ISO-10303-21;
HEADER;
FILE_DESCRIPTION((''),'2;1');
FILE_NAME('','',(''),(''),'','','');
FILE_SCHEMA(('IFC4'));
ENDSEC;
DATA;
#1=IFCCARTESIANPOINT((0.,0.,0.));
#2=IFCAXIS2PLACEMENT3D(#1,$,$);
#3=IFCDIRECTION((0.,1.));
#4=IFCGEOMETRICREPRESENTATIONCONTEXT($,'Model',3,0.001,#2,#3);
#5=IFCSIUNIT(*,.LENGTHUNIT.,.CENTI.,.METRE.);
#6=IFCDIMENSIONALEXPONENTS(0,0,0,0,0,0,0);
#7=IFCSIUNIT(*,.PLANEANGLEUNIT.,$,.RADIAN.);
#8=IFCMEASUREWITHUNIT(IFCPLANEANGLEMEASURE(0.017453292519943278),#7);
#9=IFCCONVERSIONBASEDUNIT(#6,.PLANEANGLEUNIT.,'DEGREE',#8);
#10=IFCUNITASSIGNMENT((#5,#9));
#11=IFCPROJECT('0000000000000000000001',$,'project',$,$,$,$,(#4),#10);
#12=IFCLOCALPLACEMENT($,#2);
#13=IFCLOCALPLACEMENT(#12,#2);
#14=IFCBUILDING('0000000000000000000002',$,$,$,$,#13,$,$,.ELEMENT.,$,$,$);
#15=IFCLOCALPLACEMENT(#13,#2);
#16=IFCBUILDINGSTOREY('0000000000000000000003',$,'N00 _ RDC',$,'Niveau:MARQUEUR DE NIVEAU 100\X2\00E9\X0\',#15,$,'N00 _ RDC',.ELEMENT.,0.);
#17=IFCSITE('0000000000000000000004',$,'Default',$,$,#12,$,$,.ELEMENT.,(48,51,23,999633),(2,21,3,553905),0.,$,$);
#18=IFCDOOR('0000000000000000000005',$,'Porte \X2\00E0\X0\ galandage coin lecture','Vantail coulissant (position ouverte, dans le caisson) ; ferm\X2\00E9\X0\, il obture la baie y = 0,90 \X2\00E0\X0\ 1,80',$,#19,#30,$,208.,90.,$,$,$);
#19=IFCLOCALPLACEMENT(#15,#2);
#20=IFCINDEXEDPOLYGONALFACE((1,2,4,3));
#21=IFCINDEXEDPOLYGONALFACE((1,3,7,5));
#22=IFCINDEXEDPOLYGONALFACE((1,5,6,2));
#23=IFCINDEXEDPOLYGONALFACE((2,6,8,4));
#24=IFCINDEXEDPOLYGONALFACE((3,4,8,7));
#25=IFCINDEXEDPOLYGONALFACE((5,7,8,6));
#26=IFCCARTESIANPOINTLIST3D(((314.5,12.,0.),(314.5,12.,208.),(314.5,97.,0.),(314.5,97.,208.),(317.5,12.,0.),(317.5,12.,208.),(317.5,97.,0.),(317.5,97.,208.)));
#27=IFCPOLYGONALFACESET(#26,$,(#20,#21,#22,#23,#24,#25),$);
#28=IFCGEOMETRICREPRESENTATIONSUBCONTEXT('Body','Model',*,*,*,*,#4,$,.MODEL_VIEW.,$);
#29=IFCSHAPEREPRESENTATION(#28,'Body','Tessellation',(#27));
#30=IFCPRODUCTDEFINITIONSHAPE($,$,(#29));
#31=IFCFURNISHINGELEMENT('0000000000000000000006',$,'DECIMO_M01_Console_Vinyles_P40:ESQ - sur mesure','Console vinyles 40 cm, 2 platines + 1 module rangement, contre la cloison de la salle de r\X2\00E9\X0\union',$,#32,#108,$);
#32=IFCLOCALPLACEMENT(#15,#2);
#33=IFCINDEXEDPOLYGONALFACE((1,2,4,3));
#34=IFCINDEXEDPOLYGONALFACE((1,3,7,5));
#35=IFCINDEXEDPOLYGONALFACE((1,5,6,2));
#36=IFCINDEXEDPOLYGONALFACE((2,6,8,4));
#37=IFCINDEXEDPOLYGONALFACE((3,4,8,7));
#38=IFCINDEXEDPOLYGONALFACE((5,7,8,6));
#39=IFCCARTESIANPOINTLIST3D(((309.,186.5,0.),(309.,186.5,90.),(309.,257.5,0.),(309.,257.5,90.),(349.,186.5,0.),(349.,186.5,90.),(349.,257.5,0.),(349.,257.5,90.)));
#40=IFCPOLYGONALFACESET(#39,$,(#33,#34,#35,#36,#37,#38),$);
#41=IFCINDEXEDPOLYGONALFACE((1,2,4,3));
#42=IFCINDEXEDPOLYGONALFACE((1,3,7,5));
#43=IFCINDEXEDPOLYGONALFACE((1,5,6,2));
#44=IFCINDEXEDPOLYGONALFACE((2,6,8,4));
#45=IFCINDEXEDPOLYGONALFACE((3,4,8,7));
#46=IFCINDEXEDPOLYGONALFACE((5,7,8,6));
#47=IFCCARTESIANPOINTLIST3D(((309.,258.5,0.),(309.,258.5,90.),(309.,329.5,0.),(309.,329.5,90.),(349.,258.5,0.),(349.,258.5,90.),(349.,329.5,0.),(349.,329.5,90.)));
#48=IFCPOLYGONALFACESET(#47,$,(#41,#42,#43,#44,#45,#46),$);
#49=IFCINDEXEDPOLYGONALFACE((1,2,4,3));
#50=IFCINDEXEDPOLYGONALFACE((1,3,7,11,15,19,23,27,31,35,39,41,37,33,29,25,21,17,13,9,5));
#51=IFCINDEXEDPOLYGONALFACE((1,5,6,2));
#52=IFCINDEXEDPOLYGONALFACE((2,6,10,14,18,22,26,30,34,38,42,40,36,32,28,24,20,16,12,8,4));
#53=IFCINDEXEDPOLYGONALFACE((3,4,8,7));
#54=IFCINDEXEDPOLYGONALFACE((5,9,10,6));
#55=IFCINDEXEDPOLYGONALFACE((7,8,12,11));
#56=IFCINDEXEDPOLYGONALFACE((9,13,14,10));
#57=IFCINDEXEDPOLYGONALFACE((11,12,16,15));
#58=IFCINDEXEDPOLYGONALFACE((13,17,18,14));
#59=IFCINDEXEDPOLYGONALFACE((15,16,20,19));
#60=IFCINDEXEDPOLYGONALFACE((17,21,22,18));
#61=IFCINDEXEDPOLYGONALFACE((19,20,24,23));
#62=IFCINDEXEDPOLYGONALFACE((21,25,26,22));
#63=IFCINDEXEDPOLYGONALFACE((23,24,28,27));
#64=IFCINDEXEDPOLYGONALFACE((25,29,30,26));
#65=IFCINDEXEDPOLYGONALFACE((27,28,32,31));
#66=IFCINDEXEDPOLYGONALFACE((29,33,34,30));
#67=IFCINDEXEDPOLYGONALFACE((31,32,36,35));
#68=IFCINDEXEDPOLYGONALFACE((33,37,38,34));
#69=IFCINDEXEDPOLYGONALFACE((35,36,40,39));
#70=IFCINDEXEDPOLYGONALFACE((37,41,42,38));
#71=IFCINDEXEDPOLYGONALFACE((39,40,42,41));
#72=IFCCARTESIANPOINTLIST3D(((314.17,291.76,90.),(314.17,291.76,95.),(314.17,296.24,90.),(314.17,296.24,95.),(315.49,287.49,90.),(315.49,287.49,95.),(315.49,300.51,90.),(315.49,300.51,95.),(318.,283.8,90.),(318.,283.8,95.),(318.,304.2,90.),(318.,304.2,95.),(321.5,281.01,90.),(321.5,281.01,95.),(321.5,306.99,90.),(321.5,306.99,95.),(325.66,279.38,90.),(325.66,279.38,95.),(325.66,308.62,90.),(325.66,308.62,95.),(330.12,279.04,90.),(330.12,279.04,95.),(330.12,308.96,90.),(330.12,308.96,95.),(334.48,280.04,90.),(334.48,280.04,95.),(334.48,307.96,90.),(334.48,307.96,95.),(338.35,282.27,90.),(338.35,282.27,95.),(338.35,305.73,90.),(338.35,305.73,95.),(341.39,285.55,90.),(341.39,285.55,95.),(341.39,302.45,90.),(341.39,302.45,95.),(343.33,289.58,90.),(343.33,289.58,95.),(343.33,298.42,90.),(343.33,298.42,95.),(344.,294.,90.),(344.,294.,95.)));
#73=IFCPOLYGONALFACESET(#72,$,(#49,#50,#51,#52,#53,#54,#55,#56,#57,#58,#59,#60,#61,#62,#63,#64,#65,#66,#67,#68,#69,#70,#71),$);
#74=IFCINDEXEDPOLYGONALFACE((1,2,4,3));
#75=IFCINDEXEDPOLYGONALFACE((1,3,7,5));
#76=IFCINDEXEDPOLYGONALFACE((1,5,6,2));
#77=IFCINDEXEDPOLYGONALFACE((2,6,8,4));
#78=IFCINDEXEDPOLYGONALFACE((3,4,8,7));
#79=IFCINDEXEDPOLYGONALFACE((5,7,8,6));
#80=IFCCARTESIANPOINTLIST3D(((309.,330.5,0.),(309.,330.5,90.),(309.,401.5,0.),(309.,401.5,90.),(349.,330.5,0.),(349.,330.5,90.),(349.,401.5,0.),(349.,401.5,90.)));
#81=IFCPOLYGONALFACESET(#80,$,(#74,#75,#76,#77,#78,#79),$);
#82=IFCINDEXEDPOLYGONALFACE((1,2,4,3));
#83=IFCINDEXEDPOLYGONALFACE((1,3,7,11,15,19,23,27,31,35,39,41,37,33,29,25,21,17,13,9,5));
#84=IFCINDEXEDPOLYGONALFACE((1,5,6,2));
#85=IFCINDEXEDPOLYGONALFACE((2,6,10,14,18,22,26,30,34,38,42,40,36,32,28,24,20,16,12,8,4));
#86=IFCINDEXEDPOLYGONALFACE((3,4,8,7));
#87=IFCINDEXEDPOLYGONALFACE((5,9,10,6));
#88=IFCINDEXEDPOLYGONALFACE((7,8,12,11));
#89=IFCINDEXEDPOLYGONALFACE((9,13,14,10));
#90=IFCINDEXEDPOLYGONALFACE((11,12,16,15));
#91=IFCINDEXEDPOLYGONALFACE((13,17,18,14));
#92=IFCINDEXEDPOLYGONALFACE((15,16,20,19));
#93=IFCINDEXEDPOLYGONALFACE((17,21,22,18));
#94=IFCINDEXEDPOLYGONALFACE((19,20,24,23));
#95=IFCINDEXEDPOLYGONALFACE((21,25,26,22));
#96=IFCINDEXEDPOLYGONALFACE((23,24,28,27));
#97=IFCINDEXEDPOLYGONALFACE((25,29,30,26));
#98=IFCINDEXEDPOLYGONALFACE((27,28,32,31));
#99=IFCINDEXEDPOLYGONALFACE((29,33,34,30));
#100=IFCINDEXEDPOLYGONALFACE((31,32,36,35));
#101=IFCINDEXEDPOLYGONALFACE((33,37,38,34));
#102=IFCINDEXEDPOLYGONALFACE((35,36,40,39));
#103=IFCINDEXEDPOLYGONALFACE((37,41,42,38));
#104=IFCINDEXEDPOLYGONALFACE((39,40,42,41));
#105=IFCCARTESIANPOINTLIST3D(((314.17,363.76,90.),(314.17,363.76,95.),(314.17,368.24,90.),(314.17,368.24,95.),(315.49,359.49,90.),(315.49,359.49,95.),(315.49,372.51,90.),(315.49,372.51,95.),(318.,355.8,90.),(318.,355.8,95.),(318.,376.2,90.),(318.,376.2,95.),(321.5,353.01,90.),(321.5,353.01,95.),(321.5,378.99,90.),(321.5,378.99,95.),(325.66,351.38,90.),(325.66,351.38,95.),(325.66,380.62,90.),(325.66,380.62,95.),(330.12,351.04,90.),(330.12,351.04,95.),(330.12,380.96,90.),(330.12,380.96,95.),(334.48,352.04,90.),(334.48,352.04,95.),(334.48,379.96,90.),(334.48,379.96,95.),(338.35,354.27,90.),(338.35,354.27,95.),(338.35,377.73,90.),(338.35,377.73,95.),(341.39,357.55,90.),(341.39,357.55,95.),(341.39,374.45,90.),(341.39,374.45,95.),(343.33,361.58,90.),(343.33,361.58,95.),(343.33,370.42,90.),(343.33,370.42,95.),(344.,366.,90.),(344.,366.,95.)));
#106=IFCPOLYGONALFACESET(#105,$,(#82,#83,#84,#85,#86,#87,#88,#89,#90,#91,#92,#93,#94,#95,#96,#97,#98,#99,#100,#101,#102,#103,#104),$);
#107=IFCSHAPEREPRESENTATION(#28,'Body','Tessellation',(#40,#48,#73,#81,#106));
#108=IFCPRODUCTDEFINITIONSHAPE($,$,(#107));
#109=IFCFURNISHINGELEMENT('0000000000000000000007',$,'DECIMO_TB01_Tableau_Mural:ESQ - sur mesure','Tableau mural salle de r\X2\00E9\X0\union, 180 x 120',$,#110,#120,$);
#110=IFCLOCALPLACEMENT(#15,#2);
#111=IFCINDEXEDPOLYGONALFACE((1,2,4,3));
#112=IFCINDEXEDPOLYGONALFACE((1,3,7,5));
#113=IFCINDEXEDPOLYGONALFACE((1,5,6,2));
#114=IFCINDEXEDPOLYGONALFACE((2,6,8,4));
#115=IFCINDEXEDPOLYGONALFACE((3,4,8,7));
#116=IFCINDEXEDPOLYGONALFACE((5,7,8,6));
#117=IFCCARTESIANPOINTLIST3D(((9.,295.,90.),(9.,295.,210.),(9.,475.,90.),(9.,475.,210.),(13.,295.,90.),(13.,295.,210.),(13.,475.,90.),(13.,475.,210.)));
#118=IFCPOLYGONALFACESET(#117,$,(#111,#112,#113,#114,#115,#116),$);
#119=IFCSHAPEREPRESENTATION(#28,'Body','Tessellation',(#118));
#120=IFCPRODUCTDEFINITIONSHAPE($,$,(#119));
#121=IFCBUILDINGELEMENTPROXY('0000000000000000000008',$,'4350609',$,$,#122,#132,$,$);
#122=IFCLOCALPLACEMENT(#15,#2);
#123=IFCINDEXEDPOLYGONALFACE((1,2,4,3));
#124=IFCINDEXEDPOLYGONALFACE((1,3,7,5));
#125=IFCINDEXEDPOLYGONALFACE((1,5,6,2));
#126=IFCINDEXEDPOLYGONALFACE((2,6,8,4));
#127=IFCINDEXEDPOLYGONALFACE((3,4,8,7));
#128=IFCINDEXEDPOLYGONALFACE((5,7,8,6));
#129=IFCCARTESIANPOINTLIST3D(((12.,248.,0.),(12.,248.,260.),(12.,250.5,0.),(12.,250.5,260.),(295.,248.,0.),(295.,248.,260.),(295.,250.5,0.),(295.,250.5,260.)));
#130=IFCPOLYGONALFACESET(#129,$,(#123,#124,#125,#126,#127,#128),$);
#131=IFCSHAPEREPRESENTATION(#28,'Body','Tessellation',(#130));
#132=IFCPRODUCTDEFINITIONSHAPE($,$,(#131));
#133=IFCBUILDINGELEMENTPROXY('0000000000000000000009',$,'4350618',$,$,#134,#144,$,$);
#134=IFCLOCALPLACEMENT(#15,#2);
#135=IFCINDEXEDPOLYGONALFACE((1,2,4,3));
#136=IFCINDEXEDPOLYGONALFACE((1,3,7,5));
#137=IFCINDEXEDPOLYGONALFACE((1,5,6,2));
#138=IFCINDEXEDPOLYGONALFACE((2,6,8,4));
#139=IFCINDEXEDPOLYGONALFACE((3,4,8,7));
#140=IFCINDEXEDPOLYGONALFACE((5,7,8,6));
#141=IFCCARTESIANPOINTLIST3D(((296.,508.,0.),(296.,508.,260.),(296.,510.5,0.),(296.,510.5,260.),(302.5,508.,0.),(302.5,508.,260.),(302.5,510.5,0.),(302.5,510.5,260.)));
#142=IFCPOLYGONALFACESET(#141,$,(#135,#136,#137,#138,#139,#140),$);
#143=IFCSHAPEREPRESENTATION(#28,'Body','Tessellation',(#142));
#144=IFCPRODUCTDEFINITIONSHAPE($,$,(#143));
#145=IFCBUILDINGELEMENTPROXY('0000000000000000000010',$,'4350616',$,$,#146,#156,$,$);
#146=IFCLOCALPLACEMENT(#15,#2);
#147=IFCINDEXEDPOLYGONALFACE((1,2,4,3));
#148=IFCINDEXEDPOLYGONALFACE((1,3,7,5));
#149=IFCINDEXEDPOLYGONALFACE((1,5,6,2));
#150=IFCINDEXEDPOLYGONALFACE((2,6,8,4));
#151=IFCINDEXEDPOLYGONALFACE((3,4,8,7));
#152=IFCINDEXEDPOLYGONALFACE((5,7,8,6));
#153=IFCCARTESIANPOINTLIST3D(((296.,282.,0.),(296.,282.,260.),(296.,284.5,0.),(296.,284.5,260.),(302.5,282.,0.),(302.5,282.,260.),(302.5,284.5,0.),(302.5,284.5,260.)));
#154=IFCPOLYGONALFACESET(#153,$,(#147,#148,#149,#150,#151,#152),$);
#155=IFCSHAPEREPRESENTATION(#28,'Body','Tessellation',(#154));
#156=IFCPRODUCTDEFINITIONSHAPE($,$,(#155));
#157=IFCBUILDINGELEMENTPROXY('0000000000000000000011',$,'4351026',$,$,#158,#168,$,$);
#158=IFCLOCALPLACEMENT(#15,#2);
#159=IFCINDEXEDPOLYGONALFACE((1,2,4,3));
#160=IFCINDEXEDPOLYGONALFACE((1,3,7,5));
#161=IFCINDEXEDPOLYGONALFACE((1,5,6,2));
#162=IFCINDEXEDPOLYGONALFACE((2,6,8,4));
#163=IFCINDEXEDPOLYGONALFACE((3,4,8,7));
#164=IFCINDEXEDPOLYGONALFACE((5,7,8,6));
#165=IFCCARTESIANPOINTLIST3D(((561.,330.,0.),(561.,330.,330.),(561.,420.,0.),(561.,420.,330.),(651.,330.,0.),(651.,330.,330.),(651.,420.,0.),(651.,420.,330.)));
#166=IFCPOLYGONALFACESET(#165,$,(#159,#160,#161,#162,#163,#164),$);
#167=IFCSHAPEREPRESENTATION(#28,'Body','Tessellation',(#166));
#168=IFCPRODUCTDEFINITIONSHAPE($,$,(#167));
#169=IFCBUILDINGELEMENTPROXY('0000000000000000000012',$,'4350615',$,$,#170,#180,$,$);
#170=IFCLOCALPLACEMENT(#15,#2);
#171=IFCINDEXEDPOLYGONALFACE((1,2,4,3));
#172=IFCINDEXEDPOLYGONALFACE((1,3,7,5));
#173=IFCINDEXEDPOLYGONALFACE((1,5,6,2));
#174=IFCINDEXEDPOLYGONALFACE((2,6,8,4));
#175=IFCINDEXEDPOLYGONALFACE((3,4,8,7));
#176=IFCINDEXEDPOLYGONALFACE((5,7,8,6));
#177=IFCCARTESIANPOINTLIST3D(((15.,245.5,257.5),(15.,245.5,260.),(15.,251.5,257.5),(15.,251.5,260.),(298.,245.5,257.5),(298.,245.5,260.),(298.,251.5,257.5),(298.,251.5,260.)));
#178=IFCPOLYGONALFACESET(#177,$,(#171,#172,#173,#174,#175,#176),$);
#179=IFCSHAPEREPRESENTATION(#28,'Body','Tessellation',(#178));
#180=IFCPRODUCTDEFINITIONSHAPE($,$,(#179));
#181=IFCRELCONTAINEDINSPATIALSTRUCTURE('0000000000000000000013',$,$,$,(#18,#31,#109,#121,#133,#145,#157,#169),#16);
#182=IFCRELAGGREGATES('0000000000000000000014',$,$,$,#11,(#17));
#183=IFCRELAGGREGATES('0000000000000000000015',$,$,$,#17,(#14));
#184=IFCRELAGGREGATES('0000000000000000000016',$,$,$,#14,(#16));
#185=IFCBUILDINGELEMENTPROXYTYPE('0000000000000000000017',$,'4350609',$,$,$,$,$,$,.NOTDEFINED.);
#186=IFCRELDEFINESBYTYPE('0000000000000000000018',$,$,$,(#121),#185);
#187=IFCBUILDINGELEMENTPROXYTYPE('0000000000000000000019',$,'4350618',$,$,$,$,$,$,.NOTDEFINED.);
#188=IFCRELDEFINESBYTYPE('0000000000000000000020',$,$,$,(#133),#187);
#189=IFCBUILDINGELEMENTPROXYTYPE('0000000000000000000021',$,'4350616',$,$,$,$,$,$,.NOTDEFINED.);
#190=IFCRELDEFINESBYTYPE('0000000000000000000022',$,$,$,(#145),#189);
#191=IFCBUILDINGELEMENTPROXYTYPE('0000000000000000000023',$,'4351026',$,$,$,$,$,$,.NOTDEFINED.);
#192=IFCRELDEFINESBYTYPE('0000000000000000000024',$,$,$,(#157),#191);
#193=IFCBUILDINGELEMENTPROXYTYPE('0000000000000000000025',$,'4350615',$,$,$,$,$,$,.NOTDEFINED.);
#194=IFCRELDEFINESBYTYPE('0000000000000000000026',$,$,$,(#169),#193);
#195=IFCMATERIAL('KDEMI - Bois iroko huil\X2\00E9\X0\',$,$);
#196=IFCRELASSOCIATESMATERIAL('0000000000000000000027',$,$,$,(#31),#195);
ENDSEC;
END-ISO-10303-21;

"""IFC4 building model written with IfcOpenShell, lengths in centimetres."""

from ifc_helpers import new_model, entity, si_unit, converted_unit, direction, frame, frame_2d, origin, origin_with_axes, place, context, subcontext, project, spatial, rectangle, circle, extrude, material, type_object, element, save


model = new_model("IFC4")

# Units and contexts
model_context = context("Model", 3, precision=0.001, world=origin(), true_north=direction((0.0, 1.0)))
body_context = subcontext(model_context, "Body", "Model", "MODEL_VIEW")
ifc_project = project(units=[si_unit("LENGTHUNIT", "METRE", prefix="CENTI"), converted_unit("PLANEANGLEUNIT", "DEGREE", entity("IfcPlaneAngleMeasure", 0.017453292519943278), si_unit("PLANEANGLEUNIT", "RADIAN"), dimensions=[0, 0, 0, 0, 0, 0, 0])], contexts=[model_context])

# Site, building, storey
site_placement = place(None, origin())
site = spatial("IfcSite", under=ifc_project, at=site_placement, Name="Default", CompositionType="ELEMENT", RefLatitude=(48, 51, 23, 999633), RefLongitude=(2, 21, 3, 553905), RefElevation=0.0)
building_placement = place(site_placement, origin())
building = spatial("IfcBuilding", under=site, at=building_placement, CompositionType="ELEMENT")
storey_placement = place(building_placement, origin())
storey = spatial("IfcBuildingStorey", under=building, at=storey_placement, Name="N00 _ RDC", ObjectType="Niveau:MARQUEUR DE NIVEAU 100é", LongName="N00 _ RDC", CompositionType="ELEMENT", Elevation=0.0)

# Door
door_1_placement = place(storey_placement, origin_with_axes())
element("IfcDoor", 1, at=door_1_placement, inside=storey, Name="Porte à galandage coin lecture", Description="Vantail coulissant (position ouverte, dans le caisson) ; fermé, il obture la baie y = 0,90 à 1,80", OverallHeight=208.0, OverallWidth=90.0, context=body_context, shape_type="SweptSolid", body=[
    extrude(rectangle(XDim=3.0, YDim=85.0, at=frame_2d((316.0, 54.5))), origin(), (0.0, 0.0, 1.0), 208.0),
])

# Furnishing elements
ifc_material_1 = material(Name="KDEMI - Bois iroko huilé")
furnishing_1_placement = place(storey_placement, origin_with_axes())
element("IfcFurnishingElement", 2, at=furnishing_1_placement, inside=storey, material=ifc_material_1, Name="DECIMO_M01_Console_Vinyles_P40:ESQ - sur mesure", Description="Console vinyles 40 cm, 2 platines + 1 module rangement, contre la cloison de la salle de réunion", context=body_context, shape_type="SweptSolid", body=[
    extrude(rectangle(XDim=40.0, YDim=71.0, at=frame_2d((329.0, 222.0))), origin(), (0.0, 0.0, 1.0), 90.0),
    extrude(rectangle(XDim=40.0, YDim=71.0, at=frame_2d((329.0, 294.0))), origin(), (0.0, 0.0, 1.0), 90.0),
    extrude(circle(Radius=15.0, at=frame_2d((329.0, 294.0))), frame((0.0, 0.0, 90.0)), (0.0, 0.0, 1.0), 5.0),
    extrude(rectangle(XDim=40.0, YDim=71.0, at=frame_2d((329.0, 366.0))), origin(), (0.0, 0.0, 1.0), 90.0),
    extrude(circle(Radius=15.0, at=frame_2d((329.0, 366.0))), frame((0.0, 0.0, 90.0)), (0.0, 0.0, 1.0), 5.0),
])
furnishing_2_placement = place(storey_placement, origin_with_axes())
element("IfcFurnishingElement", 3, at=furnishing_2_placement, inside=storey, Name="DECIMO_TB01_Tableau_Mural:ESQ - sur mesure", Description="Tableau mural salle de réunion, 180 x 120", context=body_context, shape_type="SweptSolid", body=[
    extrude(rectangle(XDim=4.0, YDim=180.0, at=frame_2d((11.0, 385.0))), frame((0.0, 0.0, 90.0)), (0.0, 0.0, 1.0), 120.0),
])

# Building element proxies
building_element_proxy_type_1 = type_object("IfcBuildingElementProxyType", Name="4350609", PredefinedType="NOTDEFINED")
proxy_1_placement = place(storey_placement, origin())
element("IfcBuildingElementProxy", 4, at=proxy_1_placement, inside=storey, type_object=building_element_proxy_type_1, Name="4350609", context=body_context, shape_type="SweptSolid", body=[
    extrude(rectangle(XDim=283.0, YDim=2.5, at=frame_2d((0.0, 0.0), x_axis=(1.0, 0.0))), frame((153.5, 249.25, 0.0)), (0.0, 0.0, 1.0), 260.0),
])
building_element_proxy_type_2 = type_object("IfcBuildingElementProxyType", Name="4350618", PredefinedType="NOTDEFINED")
proxy_2_placement = place(storey_placement, origin())
element("IfcBuildingElementProxy", 5, at=proxy_2_placement, inside=storey, type_object=building_element_proxy_type_2, Name="4350618", context=body_context, shape_type="SweptSolid", body=[
    extrude(rectangle(XDim=6.5, YDim=2.5, at=frame_2d((0.0, 0.0), x_axis=(1.0, 0.0))), frame((299.25, 509.25, 0.0)), (0.0, 0.0, 1.0), 260.0),
])
building_element_proxy_type_3 = type_object("IfcBuildingElementProxyType", Name="4350616", PredefinedType="NOTDEFINED")
proxy_3_placement = place(storey_placement, origin())
element("IfcBuildingElementProxy", 6, at=proxy_3_placement, inside=storey, type_object=building_element_proxy_type_3, Name="4350616", context=body_context, shape_type="SweptSolid", body=[
    extrude(rectangle(XDim=6.5, YDim=2.5, at=frame_2d((0.0, 0.0), x_axis=(1.0, 0.0))), frame((299.25, 283.25, 0.0)), (0.0, 0.0, 1.0), 260.0),
])
building_element_proxy_type_4 = type_object("IfcBuildingElementProxyType", Name="4351026", PredefinedType="NOTDEFINED")
proxy_4_placement = place(storey_placement, origin())
element("IfcBuildingElementProxy", 7, at=proxy_4_placement, inside=storey, type_object=building_element_proxy_type_4, Name="4351026", context=body_context, shape_type="SweptSolid", body=[
    extrude(rectangle(XDim=90.0, YDim=90.0, at=frame_2d((0.0, 0.0), x_axis=(1.0, 0.0))), frame((606.0, 375.0, 0.0)), (0.0, 0.0, 1.0), 330.0),
])
building_element_proxy_type_5 = type_object("IfcBuildingElementProxyType", Name="4350615", PredefinedType="NOTDEFINED")
proxy_5_placement = place(storey_placement, origin())
element("IfcBuildingElementProxy", 8, at=proxy_5_placement, inside=storey, type_object=building_element_proxy_type_5, Name="4350615", context=body_context, shape_type="SweptSolid", body=[
    extrude(rectangle(XDim=283.0, YDim=6.0, at=frame_2d((0.0, 0.0), x_axis=(1.0, 0.0))), frame((156.5, 248.5, 257.5)), (0.0, 0.0, 1.0), 2.5),
])

save(model, "model.ifc")
